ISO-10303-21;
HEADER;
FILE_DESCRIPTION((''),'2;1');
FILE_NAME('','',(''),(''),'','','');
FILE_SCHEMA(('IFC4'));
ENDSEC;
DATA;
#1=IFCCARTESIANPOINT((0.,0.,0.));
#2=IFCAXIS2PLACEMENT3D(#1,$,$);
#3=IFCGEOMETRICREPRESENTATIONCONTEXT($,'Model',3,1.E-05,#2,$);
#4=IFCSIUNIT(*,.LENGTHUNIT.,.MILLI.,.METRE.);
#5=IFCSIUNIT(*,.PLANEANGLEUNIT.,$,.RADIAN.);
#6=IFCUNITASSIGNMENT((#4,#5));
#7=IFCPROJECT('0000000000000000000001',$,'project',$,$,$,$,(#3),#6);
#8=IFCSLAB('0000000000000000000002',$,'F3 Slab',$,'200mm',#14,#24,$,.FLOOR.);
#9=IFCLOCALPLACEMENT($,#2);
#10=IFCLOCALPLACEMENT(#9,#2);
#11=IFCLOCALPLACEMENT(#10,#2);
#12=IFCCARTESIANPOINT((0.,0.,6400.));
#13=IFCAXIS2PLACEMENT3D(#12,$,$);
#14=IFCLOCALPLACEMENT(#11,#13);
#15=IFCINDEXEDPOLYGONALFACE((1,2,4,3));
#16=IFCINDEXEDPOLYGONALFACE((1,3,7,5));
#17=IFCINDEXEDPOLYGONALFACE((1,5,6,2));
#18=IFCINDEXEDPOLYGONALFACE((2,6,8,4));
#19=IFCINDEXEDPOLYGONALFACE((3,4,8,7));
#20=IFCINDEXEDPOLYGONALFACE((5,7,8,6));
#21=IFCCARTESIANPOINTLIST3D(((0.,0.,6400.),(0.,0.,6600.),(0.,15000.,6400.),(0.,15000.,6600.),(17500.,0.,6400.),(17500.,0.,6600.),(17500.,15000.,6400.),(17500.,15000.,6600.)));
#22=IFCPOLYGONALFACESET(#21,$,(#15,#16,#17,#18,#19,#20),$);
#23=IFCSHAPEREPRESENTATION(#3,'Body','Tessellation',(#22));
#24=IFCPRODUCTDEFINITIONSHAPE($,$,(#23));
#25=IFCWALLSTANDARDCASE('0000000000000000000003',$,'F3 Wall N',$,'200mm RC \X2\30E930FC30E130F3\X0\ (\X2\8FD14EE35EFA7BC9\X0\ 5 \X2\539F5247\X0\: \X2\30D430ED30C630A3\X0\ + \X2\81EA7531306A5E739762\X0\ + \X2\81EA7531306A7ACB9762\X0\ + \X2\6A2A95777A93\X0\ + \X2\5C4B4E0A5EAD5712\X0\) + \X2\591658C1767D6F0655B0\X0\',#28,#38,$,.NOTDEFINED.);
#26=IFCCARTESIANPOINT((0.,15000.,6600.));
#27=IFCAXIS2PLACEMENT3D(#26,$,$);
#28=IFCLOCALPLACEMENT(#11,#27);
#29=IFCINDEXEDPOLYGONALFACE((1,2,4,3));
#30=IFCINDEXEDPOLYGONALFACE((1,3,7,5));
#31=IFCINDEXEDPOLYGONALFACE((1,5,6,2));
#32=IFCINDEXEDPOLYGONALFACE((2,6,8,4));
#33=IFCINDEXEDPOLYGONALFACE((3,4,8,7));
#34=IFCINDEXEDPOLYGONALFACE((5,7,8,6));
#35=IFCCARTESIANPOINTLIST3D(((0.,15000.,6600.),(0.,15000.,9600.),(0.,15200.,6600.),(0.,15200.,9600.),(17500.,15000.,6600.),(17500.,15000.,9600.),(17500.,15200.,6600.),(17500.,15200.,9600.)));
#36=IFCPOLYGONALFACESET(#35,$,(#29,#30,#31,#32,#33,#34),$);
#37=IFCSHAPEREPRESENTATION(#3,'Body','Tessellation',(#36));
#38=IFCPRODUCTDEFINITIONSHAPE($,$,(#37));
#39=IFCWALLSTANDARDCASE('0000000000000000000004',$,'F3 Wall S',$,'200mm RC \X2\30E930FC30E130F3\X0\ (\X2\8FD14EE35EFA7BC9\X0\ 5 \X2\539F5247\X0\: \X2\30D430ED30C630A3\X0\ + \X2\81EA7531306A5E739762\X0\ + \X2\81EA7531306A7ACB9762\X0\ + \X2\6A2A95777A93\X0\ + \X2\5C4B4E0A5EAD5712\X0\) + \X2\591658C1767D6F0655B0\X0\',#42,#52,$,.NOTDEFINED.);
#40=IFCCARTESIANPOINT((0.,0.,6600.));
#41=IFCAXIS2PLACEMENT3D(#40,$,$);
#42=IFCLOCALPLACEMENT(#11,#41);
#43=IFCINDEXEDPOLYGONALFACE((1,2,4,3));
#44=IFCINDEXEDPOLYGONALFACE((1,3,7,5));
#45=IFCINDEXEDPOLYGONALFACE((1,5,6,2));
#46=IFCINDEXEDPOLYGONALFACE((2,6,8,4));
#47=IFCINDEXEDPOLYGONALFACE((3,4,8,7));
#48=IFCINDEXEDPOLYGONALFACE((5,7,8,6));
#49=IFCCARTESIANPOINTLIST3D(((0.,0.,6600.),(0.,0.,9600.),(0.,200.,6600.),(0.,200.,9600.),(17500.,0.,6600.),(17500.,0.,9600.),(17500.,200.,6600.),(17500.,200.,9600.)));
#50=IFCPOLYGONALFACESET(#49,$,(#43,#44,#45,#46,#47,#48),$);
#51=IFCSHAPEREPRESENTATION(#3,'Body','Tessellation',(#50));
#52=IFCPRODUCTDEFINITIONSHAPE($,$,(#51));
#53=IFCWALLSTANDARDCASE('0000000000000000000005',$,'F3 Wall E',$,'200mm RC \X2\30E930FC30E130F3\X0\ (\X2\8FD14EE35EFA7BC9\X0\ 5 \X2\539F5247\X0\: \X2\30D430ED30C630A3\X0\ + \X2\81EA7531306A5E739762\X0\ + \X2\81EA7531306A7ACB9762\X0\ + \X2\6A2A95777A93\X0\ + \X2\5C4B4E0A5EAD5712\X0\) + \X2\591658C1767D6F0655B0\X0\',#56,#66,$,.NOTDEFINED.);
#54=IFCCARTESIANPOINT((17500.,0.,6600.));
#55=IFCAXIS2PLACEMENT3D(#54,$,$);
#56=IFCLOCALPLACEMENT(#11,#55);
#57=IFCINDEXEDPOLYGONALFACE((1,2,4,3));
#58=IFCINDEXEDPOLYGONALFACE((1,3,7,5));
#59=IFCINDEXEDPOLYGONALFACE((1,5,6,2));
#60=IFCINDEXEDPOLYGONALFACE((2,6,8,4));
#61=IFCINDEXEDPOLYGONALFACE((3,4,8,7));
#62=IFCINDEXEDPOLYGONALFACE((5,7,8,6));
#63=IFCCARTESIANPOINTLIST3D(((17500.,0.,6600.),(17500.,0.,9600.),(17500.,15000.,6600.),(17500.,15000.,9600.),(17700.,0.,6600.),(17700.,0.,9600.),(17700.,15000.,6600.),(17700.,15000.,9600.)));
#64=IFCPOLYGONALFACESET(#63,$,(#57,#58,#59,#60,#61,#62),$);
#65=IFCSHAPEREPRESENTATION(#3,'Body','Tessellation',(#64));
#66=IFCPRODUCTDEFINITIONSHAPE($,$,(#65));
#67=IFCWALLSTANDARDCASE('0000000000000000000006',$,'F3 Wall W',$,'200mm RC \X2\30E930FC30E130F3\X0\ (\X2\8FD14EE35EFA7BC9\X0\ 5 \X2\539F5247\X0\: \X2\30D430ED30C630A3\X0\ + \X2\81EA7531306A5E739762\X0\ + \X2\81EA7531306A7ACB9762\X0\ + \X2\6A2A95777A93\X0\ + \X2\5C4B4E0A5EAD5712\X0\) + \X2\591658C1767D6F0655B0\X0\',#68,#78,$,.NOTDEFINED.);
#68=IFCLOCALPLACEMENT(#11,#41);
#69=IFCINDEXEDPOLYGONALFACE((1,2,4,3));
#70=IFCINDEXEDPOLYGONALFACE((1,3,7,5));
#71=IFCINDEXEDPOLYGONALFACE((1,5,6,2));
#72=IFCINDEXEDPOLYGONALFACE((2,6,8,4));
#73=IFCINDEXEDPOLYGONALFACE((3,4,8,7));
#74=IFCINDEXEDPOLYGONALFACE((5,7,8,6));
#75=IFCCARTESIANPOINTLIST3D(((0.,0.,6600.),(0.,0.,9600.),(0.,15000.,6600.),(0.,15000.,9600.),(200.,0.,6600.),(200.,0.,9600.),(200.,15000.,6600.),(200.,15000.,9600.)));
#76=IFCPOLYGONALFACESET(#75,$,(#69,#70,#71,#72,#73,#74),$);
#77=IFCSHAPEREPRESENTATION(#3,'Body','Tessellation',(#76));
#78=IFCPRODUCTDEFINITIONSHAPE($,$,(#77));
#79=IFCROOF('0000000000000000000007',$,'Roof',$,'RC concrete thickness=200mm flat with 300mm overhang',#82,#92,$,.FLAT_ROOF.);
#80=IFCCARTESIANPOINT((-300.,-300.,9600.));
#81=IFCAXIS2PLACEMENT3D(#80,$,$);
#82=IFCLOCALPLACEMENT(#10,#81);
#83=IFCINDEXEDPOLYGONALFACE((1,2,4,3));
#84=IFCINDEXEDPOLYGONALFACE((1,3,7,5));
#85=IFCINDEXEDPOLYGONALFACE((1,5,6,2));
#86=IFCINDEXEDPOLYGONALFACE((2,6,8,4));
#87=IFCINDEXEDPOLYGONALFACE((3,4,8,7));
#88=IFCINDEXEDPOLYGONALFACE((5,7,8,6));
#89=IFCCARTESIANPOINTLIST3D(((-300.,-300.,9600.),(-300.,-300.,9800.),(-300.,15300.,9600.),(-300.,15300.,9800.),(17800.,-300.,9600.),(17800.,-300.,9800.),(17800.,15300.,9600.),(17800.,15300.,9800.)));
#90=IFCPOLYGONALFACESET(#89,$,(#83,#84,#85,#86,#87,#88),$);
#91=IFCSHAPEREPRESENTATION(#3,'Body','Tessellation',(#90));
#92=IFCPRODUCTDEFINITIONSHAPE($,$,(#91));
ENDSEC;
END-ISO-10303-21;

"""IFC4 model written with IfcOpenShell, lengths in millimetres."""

from ifc_helpers import new_model, si_unit, frame, frame_2d, origin, place, context, project, rectangle, extrude, element, save


model = new_model("IFC4")

# Units and contexts
model_context = context("Model", 3, precision=1e-05, world=origin())
ifc_project = project(units=[si_unit("LENGTHUNIT", "METRE", prefix="MILLI"), si_unit("PLANEANGLEUNIT", "RADIAN")], contexts=[model_context])

# Slab
placement_1 = place(None, origin())
placement_2 = place(placement_1, origin())
placement_3 = place(placement_2, origin())
slab_placement = place(placement_3, frame((0.0, 0.0, 6400.0)))
element("IfcSlab", 1, at=slab_placement, Name="F3 Slab", ObjectType="200mm", PredefinedType="FLOOR", context=model_context, shape_type="SweptSolid", body=[
    extrude(rectangle(XDim=17500.0, YDim=15000.0, at=frame_2d((8750.0, 7500.0))), frame((0.0, 0.0, 6400.0)), (0.0, 0.0, 1.0), 200.0),
])

# Walls
wall_1_placement = place(placement_3, frame((0.0, 15000.0, 6600.0)))
element("IfcWallStandardCase", 2, at=wall_1_placement, Name="F3 Wall N", ObjectType="200mm RC ラーメン (近代建築 5 原則: ピロティ + 自由な平面 + 自由な立面 + 横長窓 + 屋上庭園) + 外壁白漆喰", PredefinedType="NOTDEFINED", context=model_context, shape_type="SweptSolid", body=[
    extrude(rectangle(XDim=17500.0, YDim=200.0, at=frame_2d((8750.0, 100.0))), frame((0.0, 15000.0, 6600.0)), (0.0, 0.0, 1.0), 3000.0),
])
wall_2_placement = place(placement_3, frame((0.0, 0.0, 6600.0)))
element("IfcWallStandardCase", 3, at=wall_2_placement, Name="F3 Wall S", ObjectType="200mm RC ラーメン (近代建築 5 原則: ピロティ + 自由な平面 + 自由な立面 + 横長窓 + 屋上庭園) + 外壁白漆喰", PredefinedType="NOTDEFINED", context=model_context, shape_type="SweptSolid", body=[
    extrude(rectangle(XDim=17500.0, YDim=200.0, at=frame_2d((8750.0, 100.0))), frame((0.0, 0.0, 6600.0)), (0.0, 0.0, 1.0), 3000.0),
])
wall_3_placement = place(placement_3, frame((17500.0, 0.0, 6600.0)))
element("IfcWallStandardCase", 4, at=wall_3_placement, Name="F3 Wall E", ObjectType="200mm RC ラーメン (近代建築 5 原則: ピロティ + 自由な平面 + 自由な立面 + 横長窓 + 屋上庭園) + 外壁白漆喰", PredefinedType="NOTDEFINED", context=model_context, shape_type="SweptSolid", body=[
    extrude(rectangle(XDim=200.0, YDim=15000.0, at=frame_2d((100.0, 7500.0))), frame((17500.0, 0.0, 6600.0)), (0.0, 0.0, 1.0), 3000.0),
])
wall_4_placement = place(placement_3, frame((0.0, 0.0, 6600.0)))
element("IfcWallStandardCase", 5, at=wall_4_placement, Name="F3 Wall W", ObjectType="200mm RC ラーメン (近代建築 5 原則: ピロティ + 自由な平面 + 自由な立面 + 横長窓 + 屋上庭園) + 外壁白漆喰", PredefinedType="NOTDEFINED", context=model_context, shape_type="SweptSolid", body=[
    extrude(rectangle(XDim=200.0, YDim=15000.0, at=frame_2d((100.0, 7500.0))), frame((0.0, 0.0, 6600.0)), (0.0, 0.0, 1.0), 3000.0),
])

# Roof
roof_placement = place(placement_2, frame((-300.0, -300.0, 9600.0)))
element("IfcRoof", 6, at=roof_placement, Name="Roof", ObjectType="RC concrete thickness=200mm flat with 300mm overhang", PredefinedType="FLAT_ROOF", context=model_context, shape_type="SweptSolid", body=[
    extrude(rectangle(XDim=18100.0, YDim=15600.0, at=frame_2d((9050.0, 7800.0))), frame((-300.0, -300.0, 9600.0)), (0.0, 0.0, 1.0), 200.0),
])

save(model, "model.ifc")
